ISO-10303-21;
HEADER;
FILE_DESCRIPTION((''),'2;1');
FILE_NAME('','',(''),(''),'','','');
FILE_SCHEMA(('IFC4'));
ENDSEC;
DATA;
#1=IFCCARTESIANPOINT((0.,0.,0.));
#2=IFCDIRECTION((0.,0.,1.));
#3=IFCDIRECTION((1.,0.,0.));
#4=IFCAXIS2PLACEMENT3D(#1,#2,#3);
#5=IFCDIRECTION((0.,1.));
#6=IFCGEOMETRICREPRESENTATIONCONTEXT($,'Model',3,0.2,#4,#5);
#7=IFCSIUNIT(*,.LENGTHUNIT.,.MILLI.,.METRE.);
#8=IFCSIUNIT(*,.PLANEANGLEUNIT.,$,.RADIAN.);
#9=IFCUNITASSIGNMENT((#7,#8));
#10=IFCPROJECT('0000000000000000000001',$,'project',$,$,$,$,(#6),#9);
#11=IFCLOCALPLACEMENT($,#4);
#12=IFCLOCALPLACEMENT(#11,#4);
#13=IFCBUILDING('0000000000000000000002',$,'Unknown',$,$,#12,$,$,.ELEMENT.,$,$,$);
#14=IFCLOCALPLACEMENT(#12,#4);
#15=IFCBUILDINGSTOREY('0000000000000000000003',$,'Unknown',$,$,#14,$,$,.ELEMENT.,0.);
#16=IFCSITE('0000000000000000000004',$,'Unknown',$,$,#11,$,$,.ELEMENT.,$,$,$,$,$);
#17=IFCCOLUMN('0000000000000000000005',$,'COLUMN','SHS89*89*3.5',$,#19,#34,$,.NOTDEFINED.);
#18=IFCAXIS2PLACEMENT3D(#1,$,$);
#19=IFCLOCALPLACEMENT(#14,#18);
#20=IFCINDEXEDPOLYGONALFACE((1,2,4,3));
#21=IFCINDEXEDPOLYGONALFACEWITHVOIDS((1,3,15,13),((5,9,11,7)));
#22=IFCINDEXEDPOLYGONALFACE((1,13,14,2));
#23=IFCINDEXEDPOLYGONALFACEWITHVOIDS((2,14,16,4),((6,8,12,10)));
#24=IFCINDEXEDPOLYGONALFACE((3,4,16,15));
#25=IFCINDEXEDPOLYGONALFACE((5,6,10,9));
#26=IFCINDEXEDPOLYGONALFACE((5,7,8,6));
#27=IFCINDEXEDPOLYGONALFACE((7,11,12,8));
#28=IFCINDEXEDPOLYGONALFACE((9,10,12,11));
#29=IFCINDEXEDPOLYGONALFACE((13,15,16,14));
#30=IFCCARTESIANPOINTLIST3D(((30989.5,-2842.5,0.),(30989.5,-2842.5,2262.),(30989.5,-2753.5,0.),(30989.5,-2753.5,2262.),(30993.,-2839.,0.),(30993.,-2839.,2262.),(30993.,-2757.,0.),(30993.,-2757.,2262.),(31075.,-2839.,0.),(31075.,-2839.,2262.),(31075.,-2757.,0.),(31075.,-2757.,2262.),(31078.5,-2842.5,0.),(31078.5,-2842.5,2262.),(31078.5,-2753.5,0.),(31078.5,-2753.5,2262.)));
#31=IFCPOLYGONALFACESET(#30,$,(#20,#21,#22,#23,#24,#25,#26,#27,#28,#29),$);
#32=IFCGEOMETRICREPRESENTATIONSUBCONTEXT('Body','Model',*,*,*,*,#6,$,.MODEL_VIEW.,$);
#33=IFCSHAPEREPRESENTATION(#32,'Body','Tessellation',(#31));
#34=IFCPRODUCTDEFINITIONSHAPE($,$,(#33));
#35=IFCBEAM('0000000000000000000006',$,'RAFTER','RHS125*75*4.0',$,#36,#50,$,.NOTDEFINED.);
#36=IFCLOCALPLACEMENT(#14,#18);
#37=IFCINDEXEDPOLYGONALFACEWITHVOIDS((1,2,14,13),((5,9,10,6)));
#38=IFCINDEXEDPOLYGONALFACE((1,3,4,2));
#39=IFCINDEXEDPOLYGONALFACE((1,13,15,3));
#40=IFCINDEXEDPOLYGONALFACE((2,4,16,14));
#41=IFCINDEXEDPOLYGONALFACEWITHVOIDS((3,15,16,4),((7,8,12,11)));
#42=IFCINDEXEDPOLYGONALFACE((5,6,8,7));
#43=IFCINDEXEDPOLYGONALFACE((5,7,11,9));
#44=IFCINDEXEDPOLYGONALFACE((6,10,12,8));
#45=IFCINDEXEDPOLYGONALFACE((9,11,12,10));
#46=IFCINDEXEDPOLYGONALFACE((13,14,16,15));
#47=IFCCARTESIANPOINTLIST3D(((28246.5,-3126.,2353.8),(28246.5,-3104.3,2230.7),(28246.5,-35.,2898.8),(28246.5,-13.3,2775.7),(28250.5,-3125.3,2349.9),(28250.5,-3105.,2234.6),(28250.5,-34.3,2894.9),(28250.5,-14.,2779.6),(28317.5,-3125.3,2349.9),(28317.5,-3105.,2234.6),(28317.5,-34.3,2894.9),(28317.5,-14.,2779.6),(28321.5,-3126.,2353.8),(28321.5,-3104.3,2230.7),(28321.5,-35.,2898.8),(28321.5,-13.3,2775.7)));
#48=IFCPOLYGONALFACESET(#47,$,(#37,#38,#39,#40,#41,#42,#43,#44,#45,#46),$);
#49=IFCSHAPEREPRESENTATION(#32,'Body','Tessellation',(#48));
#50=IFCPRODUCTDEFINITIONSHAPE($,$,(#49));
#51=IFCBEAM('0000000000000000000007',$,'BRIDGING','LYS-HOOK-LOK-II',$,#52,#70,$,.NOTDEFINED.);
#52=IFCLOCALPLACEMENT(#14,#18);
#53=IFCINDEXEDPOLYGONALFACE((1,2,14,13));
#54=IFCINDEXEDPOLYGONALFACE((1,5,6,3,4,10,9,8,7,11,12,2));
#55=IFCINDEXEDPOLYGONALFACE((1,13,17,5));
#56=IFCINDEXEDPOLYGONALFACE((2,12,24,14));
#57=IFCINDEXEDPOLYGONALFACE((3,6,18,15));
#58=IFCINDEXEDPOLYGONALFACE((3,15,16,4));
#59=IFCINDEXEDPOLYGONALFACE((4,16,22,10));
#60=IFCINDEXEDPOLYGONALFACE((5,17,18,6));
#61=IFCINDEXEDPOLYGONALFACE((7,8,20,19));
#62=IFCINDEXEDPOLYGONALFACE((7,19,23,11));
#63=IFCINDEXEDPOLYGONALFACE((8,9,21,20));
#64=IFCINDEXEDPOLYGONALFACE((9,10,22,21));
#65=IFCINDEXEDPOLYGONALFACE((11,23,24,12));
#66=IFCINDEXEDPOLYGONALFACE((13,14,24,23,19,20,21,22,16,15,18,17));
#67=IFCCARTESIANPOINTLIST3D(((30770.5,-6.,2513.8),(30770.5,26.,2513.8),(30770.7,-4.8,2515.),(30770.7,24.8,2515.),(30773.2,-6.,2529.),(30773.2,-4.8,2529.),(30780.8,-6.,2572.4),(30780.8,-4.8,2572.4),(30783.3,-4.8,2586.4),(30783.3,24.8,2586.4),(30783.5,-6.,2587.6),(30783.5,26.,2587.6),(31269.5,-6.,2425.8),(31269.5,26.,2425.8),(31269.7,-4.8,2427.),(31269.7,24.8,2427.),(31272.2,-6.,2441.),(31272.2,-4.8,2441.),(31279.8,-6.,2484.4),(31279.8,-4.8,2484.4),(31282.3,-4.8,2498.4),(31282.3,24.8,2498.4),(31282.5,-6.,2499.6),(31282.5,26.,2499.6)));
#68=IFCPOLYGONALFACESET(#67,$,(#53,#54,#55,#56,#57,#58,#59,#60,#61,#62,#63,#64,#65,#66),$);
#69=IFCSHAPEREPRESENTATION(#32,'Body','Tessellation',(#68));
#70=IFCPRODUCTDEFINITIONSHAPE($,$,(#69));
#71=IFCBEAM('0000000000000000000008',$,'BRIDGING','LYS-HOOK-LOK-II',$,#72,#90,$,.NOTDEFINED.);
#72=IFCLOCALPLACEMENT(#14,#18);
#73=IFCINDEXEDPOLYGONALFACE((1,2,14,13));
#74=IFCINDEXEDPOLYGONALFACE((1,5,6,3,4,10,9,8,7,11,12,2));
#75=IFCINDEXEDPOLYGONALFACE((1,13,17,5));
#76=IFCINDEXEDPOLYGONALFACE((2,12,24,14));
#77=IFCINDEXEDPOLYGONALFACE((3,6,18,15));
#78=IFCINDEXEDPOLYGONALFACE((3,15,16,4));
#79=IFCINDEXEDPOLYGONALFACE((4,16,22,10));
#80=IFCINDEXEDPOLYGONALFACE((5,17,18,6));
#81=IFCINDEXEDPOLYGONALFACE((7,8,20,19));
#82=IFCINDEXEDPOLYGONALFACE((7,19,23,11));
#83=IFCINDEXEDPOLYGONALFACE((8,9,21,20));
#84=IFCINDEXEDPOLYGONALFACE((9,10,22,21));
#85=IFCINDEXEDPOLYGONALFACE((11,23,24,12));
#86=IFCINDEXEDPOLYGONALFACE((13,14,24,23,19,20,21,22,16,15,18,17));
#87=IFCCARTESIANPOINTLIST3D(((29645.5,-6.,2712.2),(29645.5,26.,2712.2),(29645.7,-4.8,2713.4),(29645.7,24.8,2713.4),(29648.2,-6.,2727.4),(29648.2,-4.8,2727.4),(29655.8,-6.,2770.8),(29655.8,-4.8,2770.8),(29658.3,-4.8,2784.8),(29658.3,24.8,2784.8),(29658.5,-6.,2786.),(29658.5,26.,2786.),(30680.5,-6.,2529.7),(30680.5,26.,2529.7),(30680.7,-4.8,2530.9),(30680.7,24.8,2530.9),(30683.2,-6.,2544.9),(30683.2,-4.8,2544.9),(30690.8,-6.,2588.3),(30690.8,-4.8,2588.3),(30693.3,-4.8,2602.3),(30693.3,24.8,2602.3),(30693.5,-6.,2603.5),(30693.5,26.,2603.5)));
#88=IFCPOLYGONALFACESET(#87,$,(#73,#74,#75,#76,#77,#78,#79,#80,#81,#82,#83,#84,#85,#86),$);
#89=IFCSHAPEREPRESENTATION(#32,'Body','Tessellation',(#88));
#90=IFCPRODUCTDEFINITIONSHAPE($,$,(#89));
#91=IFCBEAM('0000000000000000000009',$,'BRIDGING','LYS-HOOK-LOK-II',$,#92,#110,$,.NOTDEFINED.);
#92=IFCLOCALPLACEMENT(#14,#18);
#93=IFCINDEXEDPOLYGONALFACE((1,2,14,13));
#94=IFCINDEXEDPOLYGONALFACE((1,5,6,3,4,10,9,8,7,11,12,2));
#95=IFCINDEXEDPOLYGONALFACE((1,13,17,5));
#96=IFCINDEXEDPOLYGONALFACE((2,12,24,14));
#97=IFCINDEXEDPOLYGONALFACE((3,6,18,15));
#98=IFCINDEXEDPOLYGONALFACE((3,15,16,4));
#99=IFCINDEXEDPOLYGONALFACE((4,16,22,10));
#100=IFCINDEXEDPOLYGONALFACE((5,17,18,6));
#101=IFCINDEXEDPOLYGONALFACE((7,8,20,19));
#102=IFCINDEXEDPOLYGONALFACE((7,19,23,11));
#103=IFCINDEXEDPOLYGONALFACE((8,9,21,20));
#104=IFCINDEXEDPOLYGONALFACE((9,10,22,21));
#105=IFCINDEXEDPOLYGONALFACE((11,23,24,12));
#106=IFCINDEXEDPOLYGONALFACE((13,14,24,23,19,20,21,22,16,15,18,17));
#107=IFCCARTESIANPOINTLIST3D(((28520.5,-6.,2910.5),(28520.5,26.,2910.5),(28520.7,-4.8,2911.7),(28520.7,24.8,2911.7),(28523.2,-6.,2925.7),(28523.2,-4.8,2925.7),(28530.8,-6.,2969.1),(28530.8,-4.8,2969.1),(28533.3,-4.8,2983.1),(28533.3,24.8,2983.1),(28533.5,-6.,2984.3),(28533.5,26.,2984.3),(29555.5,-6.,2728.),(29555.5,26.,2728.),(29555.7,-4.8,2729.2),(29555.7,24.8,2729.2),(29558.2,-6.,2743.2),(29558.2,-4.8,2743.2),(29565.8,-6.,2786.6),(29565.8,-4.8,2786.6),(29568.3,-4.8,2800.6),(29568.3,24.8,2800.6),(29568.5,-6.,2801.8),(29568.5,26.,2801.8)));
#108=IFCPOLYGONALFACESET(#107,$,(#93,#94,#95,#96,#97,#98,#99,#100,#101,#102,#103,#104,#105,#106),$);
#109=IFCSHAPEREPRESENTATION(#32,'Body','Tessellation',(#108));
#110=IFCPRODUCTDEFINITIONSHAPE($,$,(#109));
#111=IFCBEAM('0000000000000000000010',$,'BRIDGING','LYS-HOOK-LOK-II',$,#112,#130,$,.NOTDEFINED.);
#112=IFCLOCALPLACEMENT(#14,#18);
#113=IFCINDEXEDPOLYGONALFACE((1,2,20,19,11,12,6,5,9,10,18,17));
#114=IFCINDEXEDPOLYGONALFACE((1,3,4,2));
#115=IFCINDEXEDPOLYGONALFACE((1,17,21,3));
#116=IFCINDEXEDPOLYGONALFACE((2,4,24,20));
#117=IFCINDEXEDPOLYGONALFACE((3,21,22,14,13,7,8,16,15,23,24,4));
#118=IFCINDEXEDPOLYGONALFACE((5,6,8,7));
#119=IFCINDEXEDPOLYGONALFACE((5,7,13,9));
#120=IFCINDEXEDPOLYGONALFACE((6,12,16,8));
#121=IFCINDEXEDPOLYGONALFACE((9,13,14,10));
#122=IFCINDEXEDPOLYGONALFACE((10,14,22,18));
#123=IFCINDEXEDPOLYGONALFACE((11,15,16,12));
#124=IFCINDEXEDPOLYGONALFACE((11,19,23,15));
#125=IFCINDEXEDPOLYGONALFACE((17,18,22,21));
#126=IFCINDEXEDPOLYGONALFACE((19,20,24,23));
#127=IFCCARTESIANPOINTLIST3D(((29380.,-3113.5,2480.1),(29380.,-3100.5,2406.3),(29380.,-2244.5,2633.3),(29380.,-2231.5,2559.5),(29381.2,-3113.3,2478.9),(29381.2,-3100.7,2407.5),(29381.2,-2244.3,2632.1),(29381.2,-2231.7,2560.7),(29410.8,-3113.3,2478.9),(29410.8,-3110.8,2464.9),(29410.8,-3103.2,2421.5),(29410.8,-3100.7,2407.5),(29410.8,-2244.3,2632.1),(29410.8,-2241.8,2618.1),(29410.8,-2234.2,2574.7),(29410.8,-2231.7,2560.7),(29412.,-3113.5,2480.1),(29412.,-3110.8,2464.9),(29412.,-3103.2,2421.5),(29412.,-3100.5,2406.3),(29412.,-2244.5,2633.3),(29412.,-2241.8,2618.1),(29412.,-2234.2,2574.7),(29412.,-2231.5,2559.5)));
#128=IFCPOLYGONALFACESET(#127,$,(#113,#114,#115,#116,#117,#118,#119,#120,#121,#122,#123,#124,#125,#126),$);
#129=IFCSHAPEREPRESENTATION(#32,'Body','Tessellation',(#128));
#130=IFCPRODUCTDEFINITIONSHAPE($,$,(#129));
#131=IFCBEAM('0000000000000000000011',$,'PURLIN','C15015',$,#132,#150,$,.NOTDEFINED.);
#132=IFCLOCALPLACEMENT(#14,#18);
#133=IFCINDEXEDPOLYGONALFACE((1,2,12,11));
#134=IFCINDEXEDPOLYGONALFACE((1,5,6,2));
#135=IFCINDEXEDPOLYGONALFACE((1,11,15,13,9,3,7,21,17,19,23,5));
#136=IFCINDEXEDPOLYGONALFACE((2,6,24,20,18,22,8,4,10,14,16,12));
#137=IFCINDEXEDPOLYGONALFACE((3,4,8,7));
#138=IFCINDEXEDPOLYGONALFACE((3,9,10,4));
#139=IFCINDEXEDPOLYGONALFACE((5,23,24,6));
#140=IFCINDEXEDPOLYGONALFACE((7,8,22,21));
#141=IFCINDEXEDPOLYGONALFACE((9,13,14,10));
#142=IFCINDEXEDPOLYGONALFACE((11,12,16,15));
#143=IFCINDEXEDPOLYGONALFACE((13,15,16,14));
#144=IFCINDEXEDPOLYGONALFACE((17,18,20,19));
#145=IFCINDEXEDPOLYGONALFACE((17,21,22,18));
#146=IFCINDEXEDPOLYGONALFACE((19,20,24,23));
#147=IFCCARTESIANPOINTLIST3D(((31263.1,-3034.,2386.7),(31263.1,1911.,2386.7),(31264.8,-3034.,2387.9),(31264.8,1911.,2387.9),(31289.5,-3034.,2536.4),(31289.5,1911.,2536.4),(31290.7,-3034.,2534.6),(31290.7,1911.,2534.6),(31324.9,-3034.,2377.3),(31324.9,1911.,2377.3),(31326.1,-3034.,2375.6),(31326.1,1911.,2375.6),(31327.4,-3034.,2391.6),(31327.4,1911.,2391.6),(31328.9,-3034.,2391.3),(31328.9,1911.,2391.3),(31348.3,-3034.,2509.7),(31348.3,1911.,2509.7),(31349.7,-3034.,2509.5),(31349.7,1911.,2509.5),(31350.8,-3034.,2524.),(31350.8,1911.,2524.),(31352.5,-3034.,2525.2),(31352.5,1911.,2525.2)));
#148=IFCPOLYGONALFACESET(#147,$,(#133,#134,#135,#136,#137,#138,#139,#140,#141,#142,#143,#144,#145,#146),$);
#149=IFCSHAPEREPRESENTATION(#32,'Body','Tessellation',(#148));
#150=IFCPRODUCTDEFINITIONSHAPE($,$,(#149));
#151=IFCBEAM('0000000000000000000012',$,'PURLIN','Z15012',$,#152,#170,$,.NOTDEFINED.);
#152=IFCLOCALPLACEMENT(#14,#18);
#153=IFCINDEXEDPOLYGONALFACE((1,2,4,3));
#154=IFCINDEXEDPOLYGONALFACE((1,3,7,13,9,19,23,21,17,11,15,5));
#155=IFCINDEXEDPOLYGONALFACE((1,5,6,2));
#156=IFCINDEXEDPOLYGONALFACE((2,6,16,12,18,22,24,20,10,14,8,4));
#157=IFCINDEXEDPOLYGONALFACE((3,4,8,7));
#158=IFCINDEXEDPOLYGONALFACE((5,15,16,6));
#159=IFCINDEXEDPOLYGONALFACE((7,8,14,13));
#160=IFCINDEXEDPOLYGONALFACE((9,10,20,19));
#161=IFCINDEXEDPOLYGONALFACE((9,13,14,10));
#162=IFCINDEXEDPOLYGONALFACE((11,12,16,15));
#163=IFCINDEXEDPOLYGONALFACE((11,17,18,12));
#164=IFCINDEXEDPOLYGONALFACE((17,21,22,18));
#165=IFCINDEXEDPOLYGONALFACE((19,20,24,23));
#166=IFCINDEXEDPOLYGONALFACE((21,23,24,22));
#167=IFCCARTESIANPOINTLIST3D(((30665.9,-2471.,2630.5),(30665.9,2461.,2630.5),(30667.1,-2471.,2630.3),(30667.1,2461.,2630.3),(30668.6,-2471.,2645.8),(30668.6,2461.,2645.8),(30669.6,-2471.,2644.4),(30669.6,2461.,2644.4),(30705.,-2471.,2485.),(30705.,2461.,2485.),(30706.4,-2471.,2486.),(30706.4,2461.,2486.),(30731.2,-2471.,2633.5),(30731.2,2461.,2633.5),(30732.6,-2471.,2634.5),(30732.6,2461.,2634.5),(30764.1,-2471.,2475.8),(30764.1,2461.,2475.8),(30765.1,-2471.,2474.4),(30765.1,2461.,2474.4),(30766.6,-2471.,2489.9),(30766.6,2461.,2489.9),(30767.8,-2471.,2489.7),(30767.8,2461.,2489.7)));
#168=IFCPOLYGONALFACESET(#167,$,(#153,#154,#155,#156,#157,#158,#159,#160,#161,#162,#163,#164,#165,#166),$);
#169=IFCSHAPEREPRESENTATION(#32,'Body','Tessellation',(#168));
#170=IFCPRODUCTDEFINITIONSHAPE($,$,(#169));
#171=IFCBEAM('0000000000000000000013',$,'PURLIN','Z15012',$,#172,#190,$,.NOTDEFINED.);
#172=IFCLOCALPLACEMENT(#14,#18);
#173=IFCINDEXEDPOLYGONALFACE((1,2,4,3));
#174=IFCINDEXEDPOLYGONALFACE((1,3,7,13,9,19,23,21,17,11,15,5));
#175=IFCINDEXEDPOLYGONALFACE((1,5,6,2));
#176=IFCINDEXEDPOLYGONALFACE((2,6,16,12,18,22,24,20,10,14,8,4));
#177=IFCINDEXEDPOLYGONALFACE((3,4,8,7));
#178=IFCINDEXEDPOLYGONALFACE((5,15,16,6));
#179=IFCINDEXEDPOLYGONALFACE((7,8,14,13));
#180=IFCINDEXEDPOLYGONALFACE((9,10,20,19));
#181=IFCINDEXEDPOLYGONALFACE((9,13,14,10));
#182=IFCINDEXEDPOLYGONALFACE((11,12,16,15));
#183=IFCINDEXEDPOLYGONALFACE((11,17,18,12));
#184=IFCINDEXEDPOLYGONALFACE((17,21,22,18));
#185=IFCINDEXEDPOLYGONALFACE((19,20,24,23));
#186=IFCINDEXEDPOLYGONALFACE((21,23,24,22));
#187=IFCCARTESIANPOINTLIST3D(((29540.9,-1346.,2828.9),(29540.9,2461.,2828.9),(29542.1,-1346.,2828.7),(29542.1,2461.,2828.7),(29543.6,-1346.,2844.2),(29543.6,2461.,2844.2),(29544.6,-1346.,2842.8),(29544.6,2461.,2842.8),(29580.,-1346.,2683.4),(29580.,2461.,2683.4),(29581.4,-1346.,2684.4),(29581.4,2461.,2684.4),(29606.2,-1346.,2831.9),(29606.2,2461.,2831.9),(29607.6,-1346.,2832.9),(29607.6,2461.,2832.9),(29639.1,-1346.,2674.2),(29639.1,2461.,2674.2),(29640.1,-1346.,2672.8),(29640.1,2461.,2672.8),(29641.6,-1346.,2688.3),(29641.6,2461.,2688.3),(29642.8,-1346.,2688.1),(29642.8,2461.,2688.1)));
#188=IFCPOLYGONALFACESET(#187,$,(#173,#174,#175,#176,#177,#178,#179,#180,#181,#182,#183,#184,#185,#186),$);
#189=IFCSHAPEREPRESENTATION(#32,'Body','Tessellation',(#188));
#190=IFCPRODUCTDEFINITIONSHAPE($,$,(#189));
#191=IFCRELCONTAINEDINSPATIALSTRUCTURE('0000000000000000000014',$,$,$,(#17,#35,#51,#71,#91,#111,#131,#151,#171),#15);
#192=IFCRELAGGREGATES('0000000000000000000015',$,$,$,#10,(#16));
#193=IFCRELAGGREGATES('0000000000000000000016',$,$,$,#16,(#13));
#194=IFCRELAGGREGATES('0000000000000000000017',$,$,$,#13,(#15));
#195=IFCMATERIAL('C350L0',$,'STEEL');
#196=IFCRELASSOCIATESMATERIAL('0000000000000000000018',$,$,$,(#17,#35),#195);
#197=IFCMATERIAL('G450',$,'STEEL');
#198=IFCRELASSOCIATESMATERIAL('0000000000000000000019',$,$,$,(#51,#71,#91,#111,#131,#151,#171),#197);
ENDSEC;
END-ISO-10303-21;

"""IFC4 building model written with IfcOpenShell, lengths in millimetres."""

from ifc_helpers import new_model, si_unit, direction, frame, origin_with_axes, place, context, subcontext, project, spatial, line, indexed_curve, outline, extrude, material, element, save


model = new_model("IFC4")

# Units and contexts
model_context = context("Model", 3, precision=0.2, world=origin_with_axes(), true_north=direction((0.0, 1.0)))
body_context = subcontext(model_context, "Body", "Model", "MODEL_VIEW")
ifc_project = project(units=[si_unit("LENGTHUNIT", "METRE", prefix="MILLI"), si_unit("PLANEANGLEUNIT", "RADIAN")], contexts=[model_context])

# Site, building, storey
site_placement = place(None, origin_with_axes())
site = spatial("IfcSite", under=ifc_project, at=site_placement, Name="Unknown", CompositionType="ELEMENT")
building_placement = place(site_placement, origin_with_axes())
building = spatial("IfcBuilding", under=site, at=building_placement, Name="Unknown", CompositionType="ELEMENT")
storey_placement = place(building_placement, origin_with_axes())
storey = spatial("IfcBuildingStorey", under=building, at=storey_placement, Name="Unknown", CompositionType="ELEMENT", Elevation=0.0)

# Column
ifc_material_1 = material(Name="C350L0", Category="STEEL")
column_placement = place(storey_placement, frame((31034.0, -2798.0, 0.0), z_axis=(-1.0, 0.0, 0.0), x_axis=(0.0, 0.0, 1.0)))
element("IfcColumn", 1, at=column_placement, inside=storey, material=ifc_material_1, Name="COLUMN", Description="SHS89*89*3.5", PredefinedType="NOTDEFINED", context=body_context, shape_type="SolidModel", body=[
    extrude(outline(indexed_curve([(-44.5, -44.5), (44.5, -44.5), (44.5, 44.5), (-44.5, 44.5)], segments=[line(1, 2, 3, 4, 1)]), holes=[indexed_curve([(-41.0, -41.0), (-41.0, 41.0), (41.0, 41.0), (41.0, -41.0)], segments=[line(1, 2, 3, 4, 1)])]), frame((0.0, 0.0, 0.0), z_axis=(-1.0, 0.0, 0.0), x_axis=(0.0, 0.0, 1.0)), (0.0, 0.0, -1.0), 2262.0),
])

# Beams
beam_1_placement = place(storey_placement, frame((28284.0, -24.1, 2837.2), z_axis=(-1.0, 0.0, 0.0), x_axis=(0.0, -0.984809, -0.17364)))
element("IfcBeam", 2, at=beam_1_placement, inside=storey, material=ifc_material_1, Name="RAFTER", Description="RHS125*75*4.0", PredefinedType="NOTDEFINED", context=body_context, shape_type="SolidModel", body=[
    extrude(outline(indexed_curve([(-37.5, -62.5), (37.5, -62.5), (37.5, 62.5), (-37.5, 62.5)], segments=[line(1, 2, 3, 4, 1)]), holes=[indexed_curve([(-33.5, -58.5), (-33.5, 58.5), (33.5, 58.5), (33.5, -58.5)], segments=[line(1, 2, 3, 4, 1)])]), frame((0.0, 0.0, 0.0), z_axis=(-1.0, 0.0, 0.0), x_axis=(0.0, 0.0, 1.0)), (0.0, 0.0, -1.0), 3138.7),
])
ifc_material_2 = material(Name="G450", Category="STEEL")
beam_2_placement = place(storey_placement, frame((30777.0, 10.0, 2550.7), z_axis=(0.0, -1.0, 0.0), x_axis=(0.984803, 0.0, -0.173673)))
element("IfcBeam", 3, at=beam_2_placement, inside=storey, material=ifc_material_2, Name="BRIDGING", Description="LYS-HOOK-LOK-II", PredefinedType="NOTDEFINED", context=body_context, shape_type="SolidModel", body=[
    extrude(outline(indexed_curve([(16.0, -37.5), (16.0, -22.0), (14.8, -22.0), (14.8, -36.3), (-14.8, -36.3), (-14.8, 36.3), (14.8, 36.3), (14.8, 22.0), (16.0, 22.0), (16.0, 37.5), (-16.0, 37.5), (-16.0, -37.5)], segments=[line(1, 2, 3, 4, 5, 6, 7, 8, 9, 10, 11, 12, 1)])), frame((0.0, 0.0, 0.0), z_axis=(-1.0, 0.0, 0.0), x_axis=(0.0, 0.0, 1.0)), (0.0, 0.0, -1.0), 506.7),
])
for number, where, z_axis, x_axis, name in (
    (4, (29652.0, 10.0, 2749.1), (0.0, -1.0, 0.0), (0.984807, 0.0, -0.17365), "BRIDGING"),
    (5, (28527.0, 10.0, 2947.4), (0.0, -1.0, 0.0), (0.984807, 0.0, -0.17365), "BRIDGING"),
):
    element("IfcBeam", number, at=place(storey_placement, frame(where, z_axis=z_axis, x_axis=x_axis)), inside=storey, material=ifc_material_2, Name=name, Description="LYS-HOOK-LOK-II", PredefinedType="NOTDEFINED", context=body_context, shape_type="SolidModel", body=[
        extrude(outline(indexed_curve([(16.0, -37.5), (16.0, -22.0), (14.8, -22.0), (14.8, -36.3), (-14.8, -36.3), (-14.8, 36.3), (14.8, 36.3), (14.8, 22.0), (16.0, 22.0), (16.0, 37.5), (-16.0, 37.5), (-16.0, -37.5)], segments=[line(1, 2, 3, 4, 5, 6, 7, 8, 9, 10, 11, 12, 1)])), frame((0.0, 0.0, 0.0), z_axis=(-1.0, 0.0, 0.0), x_axis=(0.0, 0.0, 1.0)), (0.0, 0.0, -1.0), 1051.0),
    ])
beam_3_placement = place(storey_placement, frame((29396.0, -3107.0, 2443.2), z_axis=(1.0, 0.0, 0.0), x_axis=(0.0, 0.984813, 0.173617)))
element("IfcBeam", 6, at=beam_3_placement, inside=storey, material=ifc_material_2, Name="BRIDGING", Description="LYS-HOOK-LOK-II", PredefinedType="NOTDEFINED", context=body_context, shape_type="SolidModel", body=[
    extrude(outline(indexed_curve([(16.0, -37.5), (16.0, -22.0), (14.8, -22.0), (14.8, -36.3), (-14.8, -36.3), (-14.8, 36.3), (14.8, 36.3), (14.8, 22.0), (16.0, 22.0), (16.0, 37.5), (-16.0, 37.5), (-16.0, -37.5)], segments=[line(1, 2, 3, 4, 5, 6, 7, 8, 9, 10, 11, 12, 1)])), frame((0.0, 0.0, 0.0), z_axis=(-1.0, 0.0, 0.0), x_axis=(0.0, 0.0, 1.0)), (0.0, 0.0, -1.0), 882.4),
])
beam_4_placement = place(storey_placement, frame((31307.8, -3034.0, 2456.0), z_axis=(0.984808, 0.0, -0.173648), x_axis=(0.0, 1.0, 0.0)))
element("IfcBeam", 7, at=beam_4_placement, inside=storey, material=ifc_material_2, Name="PURLIN", Description="C15015", PredefinedType="NOTDEFINED", context=body_context, shape_type="SolidModel", body=[
    extrude(outline(indexed_curve([(32.0, -76.0), (32.0, -60.0), (30.5, -60.0), (30.5, -74.5), (-30.5, -74.5), (-30.5, 74.5), (30.5, 74.5), (30.5, 60.0), (32.0, 60.0), (32.0, 76.0), (-32.0, 76.0), (-32.0, -76.0)], segments=[line(1, 2, 3, 4, 5, 6, 7, 8, 9, 10, 11, 12, 1)])), frame((0.0, 0.0, 0.0), z_axis=(-1.0, 0.0, 0.0), x_axis=(0.0, 0.0, 1.0)), (0.0, 0.0, -1.0), 4945.0),
])
beam_5_placement = place(storey_placement, frame((30718.8, -2471.0, 2559.8), z_axis=(0.984808, 0.0, -0.173648), x_axis=(0.0, 1.0, 0.0)))
element("IfcBeam", 8, at=beam_5_placement, inside=storey, material=ifc_material_2, Name="PURLIN", Description="Z15012", PredefinedType="NOTDEFINED", context=body_context, shape_type="SolidModel", body=[
    extrude(outline(indexed_curve([(60.4, -76.0), (60.4, -60.5), (59.2, -60.5), (59.2, -74.8), (0.6, -74.8), (0.6, 76.0), (-64.4, 76.0), (-64.4, 60.5), (-63.2, 60.5), (-63.2, 74.8), (-0.6, 74.8), (-0.6, -76.0)], segments=[line(1, 2, 3, 4, 5, 6, 7, 8, 9, 10, 11, 12, 1)])), frame((0.0, 0.0, 0.0), z_axis=(-1.0, 0.0, 0.0), x_axis=(0.0, 0.0, 1.0)), (0.0, 0.0, -1.0), 4932.0),
])
beam_6_placement = place(storey_placement, frame((29593.8, -1346.0, 2758.2), z_axis=(0.984808, 0.0, -0.173648), x_axis=(0.0, 1.0, 0.0)))
element("IfcBeam", 9, at=beam_6_placement, inside=storey, material=ifc_material_2, Name="PURLIN", Description="Z15012", PredefinedType="NOTDEFINED", context=body_context, shape_type="SolidModel", body=[
    extrude(outline(indexed_curve([(60.4, -76.0), (60.4, -60.5), (59.2, -60.5), (59.2, -74.8), (0.6, -74.8), (0.6, 76.0), (-64.4, 76.0), (-64.4, 60.5), (-63.2, 60.5), (-63.2, 74.8), (-0.6, 74.8), (-0.6, -76.0)], segments=[line(1, 2, 3, 4, 5, 6, 7, 8, 9, 10, 11, 12, 1)])), frame((0.0, 0.0, 0.0), z_axis=(-1.0, 0.0, 0.0), x_axis=(0.0, 0.0, 1.0)), (0.0, 0.0, -1.0), 3807.0),
])

save(model, "model.ifc")
